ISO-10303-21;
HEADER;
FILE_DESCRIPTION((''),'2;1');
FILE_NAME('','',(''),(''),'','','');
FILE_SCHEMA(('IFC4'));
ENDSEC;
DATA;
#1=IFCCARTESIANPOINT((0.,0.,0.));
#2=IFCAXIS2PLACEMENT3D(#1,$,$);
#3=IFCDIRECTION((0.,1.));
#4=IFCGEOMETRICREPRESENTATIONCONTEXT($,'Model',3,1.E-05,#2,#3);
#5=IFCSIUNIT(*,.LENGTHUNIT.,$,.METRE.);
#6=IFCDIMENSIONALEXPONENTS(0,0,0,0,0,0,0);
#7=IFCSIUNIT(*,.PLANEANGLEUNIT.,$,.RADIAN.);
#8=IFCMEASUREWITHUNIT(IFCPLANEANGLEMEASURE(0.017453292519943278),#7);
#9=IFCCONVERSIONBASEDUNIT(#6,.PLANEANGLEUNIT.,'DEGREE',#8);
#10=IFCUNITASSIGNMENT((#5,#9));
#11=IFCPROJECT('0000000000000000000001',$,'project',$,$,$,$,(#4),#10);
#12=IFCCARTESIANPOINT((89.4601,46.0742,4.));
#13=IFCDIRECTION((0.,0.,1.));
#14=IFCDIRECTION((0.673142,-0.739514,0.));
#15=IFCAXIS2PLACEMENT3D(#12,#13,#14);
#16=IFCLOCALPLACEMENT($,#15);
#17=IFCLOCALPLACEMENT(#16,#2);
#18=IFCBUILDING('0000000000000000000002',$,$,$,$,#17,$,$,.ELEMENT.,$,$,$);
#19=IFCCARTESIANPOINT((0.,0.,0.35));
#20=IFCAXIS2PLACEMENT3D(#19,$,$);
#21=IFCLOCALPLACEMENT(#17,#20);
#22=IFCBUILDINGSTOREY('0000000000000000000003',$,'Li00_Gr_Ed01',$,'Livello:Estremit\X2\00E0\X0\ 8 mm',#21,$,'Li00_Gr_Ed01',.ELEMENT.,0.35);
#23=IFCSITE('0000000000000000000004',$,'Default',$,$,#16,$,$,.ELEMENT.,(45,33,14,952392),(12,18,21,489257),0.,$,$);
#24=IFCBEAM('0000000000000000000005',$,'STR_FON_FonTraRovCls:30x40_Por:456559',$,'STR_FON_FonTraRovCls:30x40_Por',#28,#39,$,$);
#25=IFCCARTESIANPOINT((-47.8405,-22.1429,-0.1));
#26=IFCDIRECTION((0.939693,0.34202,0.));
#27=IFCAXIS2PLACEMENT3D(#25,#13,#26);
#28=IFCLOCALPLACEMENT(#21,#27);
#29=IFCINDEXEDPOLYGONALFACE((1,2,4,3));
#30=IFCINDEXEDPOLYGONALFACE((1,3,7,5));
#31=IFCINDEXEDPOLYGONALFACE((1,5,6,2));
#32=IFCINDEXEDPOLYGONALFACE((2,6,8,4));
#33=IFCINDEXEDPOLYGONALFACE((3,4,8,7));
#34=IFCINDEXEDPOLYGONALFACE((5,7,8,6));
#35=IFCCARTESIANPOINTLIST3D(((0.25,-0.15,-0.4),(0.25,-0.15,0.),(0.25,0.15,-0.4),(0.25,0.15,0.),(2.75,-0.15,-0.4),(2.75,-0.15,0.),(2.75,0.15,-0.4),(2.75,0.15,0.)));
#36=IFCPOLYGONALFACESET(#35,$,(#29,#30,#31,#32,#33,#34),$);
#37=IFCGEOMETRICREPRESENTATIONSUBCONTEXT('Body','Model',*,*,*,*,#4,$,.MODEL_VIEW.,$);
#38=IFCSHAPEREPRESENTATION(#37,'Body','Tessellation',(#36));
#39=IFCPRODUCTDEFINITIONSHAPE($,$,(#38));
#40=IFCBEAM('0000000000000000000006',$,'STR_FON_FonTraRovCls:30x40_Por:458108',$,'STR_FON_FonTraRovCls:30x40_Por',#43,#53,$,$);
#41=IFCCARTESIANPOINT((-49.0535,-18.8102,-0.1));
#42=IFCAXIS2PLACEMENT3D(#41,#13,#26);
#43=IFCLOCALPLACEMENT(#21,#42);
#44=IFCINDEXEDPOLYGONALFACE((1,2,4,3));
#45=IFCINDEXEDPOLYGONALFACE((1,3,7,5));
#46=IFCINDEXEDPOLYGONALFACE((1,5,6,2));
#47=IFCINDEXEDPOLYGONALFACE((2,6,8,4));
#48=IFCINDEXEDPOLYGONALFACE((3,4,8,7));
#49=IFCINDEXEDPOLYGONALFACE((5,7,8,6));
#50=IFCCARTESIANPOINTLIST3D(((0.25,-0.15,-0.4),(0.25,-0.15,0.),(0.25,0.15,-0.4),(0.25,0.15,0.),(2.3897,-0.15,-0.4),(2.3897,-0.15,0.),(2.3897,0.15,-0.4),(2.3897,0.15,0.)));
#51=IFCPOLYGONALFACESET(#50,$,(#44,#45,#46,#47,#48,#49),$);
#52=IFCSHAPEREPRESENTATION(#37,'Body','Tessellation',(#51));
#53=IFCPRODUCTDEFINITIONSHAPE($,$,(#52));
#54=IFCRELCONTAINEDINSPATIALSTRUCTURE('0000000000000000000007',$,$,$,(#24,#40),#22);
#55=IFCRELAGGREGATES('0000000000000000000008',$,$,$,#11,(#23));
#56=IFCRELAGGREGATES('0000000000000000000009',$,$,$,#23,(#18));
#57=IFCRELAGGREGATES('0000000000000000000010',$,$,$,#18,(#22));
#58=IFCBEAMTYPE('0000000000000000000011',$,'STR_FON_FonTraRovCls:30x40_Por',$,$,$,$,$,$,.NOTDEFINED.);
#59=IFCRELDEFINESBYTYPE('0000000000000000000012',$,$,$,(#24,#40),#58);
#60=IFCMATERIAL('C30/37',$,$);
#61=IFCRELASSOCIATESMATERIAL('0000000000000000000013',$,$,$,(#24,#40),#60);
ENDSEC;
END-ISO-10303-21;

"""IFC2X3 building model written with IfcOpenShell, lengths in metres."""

from ifc_helpers import new_model, entity, si_unit, converted_unit, direction, frame, frame_2d, origin, place, context, subcontext, project, spatial, rectangle, extrude, material, type_object, element, save


model = new_model("IFC2X3")

# Units and contexts
model_context = context("Model", 3, precision=1e-05, world=origin(), true_north=direction((0.0, 1.0)))
body_context = subcontext(model_context, "Body", "Model", "MODEL_VIEW")
ifc_project = project(units=[si_unit("LENGTHUNIT", "METRE"), converted_unit("PLANEANGLEUNIT", "DEGREE", entity("IfcPlaneAngleMeasure", 0.017453292519943278), si_unit("PLANEANGLEUNIT", "RADIAN"), dimensions=[0, 0, 0, 0, 0, 0, 0])], contexts=[model_context])

# Site, building, storey
site_placement = place(None, frame((89.4601, 46.0742, 4.0), z_axis=(0.0, 0.0, 1.0), x_axis=(0.673142, -0.739514, 0.0)))
site = spatial("IfcSite", under=ifc_project, at=site_placement, Name="Default", CompositionType="ELEMENT", RefLatitude=(45, 33, 14, 952392), RefLongitude=(12, 18, 21, 489257), RefElevation=0.0)
building_placement = place(site_placement, origin())
building = spatial("IfcBuilding", under=site, at=building_placement, CompositionType="ELEMENT")
storey_placement = place(building_placement, frame((0.0, 0.0, 0.35)))
storey = spatial("IfcBuildingStorey", under=building, at=storey_placement, Name="Li00_Gr_Ed01", ObjectType="Livello:Estremità 8 mm", LongName="Li00_Gr_Ed01", CompositionType="ELEMENT", Elevation=0.35)

# Beams
ifc_material_1 = material(Name="C30/37")
beam_type_1 = type_object("IfcBeamType", Name="STR_FON_FonTraRovCls:30x40_Por", PredefinedType="NOTDEFINED")
beam_1_placement = place(storey_placement, frame((-47.8405, -22.1429, -0.1), z_axis=(0.0, 0.0, 1.0), x_axis=(0.939693, 0.34202, 0.0)))
element("IfcBeam", 1, at=beam_1_placement, inside=storey, type_object=beam_type_1, material=ifc_material_1, Name="STR_FON_FonTraRovCls:30x40_Por:456559", ObjectType="STR_FON_FonTraRovCls:30x40_Por", context=body_context, shape_type="SweptSolid", body=[
    extrude(rectangle(XDim=0.4, YDim=0.3, at=frame_2d((0.0, 0.0), x_axis=(1.0, 0.0))), frame((0.25, 0.0, -0.2), z_axis=(1.0, 0.0, 0.0), x_axis=(0.0, 0.0, -1.0)), (0.0, 0.0, 1.0), 2.5),
])
beam_2_placement = place(storey_placement, frame((-49.0535, -18.8102, -0.1), z_axis=(0.0, 0.0, 1.0), x_axis=(0.939693, 0.34202, 0.0)))
element("IfcBeam", 2, at=beam_2_placement, inside=storey, type_object=beam_type_1, material=ifc_material_1, Name="STR_FON_FonTraRovCls:30x40_Por:458108", ObjectType="STR_FON_FonTraRovCls:30x40_Por", context=body_context, shape_type="SweptSolid", body=[
    extrude(rectangle(XDim=0.4, YDim=0.3, at=frame_2d((0.0, 0.0), x_axis=(1.0, 0.0))), frame((0.25, 0.0, -0.2), z_axis=(1.0, 0.0, 0.0), x_axis=(0.0, 0.0, -1.0)), (0.0, 0.0, 1.0), 2.1397),
])

save(model, "model.ifc")
